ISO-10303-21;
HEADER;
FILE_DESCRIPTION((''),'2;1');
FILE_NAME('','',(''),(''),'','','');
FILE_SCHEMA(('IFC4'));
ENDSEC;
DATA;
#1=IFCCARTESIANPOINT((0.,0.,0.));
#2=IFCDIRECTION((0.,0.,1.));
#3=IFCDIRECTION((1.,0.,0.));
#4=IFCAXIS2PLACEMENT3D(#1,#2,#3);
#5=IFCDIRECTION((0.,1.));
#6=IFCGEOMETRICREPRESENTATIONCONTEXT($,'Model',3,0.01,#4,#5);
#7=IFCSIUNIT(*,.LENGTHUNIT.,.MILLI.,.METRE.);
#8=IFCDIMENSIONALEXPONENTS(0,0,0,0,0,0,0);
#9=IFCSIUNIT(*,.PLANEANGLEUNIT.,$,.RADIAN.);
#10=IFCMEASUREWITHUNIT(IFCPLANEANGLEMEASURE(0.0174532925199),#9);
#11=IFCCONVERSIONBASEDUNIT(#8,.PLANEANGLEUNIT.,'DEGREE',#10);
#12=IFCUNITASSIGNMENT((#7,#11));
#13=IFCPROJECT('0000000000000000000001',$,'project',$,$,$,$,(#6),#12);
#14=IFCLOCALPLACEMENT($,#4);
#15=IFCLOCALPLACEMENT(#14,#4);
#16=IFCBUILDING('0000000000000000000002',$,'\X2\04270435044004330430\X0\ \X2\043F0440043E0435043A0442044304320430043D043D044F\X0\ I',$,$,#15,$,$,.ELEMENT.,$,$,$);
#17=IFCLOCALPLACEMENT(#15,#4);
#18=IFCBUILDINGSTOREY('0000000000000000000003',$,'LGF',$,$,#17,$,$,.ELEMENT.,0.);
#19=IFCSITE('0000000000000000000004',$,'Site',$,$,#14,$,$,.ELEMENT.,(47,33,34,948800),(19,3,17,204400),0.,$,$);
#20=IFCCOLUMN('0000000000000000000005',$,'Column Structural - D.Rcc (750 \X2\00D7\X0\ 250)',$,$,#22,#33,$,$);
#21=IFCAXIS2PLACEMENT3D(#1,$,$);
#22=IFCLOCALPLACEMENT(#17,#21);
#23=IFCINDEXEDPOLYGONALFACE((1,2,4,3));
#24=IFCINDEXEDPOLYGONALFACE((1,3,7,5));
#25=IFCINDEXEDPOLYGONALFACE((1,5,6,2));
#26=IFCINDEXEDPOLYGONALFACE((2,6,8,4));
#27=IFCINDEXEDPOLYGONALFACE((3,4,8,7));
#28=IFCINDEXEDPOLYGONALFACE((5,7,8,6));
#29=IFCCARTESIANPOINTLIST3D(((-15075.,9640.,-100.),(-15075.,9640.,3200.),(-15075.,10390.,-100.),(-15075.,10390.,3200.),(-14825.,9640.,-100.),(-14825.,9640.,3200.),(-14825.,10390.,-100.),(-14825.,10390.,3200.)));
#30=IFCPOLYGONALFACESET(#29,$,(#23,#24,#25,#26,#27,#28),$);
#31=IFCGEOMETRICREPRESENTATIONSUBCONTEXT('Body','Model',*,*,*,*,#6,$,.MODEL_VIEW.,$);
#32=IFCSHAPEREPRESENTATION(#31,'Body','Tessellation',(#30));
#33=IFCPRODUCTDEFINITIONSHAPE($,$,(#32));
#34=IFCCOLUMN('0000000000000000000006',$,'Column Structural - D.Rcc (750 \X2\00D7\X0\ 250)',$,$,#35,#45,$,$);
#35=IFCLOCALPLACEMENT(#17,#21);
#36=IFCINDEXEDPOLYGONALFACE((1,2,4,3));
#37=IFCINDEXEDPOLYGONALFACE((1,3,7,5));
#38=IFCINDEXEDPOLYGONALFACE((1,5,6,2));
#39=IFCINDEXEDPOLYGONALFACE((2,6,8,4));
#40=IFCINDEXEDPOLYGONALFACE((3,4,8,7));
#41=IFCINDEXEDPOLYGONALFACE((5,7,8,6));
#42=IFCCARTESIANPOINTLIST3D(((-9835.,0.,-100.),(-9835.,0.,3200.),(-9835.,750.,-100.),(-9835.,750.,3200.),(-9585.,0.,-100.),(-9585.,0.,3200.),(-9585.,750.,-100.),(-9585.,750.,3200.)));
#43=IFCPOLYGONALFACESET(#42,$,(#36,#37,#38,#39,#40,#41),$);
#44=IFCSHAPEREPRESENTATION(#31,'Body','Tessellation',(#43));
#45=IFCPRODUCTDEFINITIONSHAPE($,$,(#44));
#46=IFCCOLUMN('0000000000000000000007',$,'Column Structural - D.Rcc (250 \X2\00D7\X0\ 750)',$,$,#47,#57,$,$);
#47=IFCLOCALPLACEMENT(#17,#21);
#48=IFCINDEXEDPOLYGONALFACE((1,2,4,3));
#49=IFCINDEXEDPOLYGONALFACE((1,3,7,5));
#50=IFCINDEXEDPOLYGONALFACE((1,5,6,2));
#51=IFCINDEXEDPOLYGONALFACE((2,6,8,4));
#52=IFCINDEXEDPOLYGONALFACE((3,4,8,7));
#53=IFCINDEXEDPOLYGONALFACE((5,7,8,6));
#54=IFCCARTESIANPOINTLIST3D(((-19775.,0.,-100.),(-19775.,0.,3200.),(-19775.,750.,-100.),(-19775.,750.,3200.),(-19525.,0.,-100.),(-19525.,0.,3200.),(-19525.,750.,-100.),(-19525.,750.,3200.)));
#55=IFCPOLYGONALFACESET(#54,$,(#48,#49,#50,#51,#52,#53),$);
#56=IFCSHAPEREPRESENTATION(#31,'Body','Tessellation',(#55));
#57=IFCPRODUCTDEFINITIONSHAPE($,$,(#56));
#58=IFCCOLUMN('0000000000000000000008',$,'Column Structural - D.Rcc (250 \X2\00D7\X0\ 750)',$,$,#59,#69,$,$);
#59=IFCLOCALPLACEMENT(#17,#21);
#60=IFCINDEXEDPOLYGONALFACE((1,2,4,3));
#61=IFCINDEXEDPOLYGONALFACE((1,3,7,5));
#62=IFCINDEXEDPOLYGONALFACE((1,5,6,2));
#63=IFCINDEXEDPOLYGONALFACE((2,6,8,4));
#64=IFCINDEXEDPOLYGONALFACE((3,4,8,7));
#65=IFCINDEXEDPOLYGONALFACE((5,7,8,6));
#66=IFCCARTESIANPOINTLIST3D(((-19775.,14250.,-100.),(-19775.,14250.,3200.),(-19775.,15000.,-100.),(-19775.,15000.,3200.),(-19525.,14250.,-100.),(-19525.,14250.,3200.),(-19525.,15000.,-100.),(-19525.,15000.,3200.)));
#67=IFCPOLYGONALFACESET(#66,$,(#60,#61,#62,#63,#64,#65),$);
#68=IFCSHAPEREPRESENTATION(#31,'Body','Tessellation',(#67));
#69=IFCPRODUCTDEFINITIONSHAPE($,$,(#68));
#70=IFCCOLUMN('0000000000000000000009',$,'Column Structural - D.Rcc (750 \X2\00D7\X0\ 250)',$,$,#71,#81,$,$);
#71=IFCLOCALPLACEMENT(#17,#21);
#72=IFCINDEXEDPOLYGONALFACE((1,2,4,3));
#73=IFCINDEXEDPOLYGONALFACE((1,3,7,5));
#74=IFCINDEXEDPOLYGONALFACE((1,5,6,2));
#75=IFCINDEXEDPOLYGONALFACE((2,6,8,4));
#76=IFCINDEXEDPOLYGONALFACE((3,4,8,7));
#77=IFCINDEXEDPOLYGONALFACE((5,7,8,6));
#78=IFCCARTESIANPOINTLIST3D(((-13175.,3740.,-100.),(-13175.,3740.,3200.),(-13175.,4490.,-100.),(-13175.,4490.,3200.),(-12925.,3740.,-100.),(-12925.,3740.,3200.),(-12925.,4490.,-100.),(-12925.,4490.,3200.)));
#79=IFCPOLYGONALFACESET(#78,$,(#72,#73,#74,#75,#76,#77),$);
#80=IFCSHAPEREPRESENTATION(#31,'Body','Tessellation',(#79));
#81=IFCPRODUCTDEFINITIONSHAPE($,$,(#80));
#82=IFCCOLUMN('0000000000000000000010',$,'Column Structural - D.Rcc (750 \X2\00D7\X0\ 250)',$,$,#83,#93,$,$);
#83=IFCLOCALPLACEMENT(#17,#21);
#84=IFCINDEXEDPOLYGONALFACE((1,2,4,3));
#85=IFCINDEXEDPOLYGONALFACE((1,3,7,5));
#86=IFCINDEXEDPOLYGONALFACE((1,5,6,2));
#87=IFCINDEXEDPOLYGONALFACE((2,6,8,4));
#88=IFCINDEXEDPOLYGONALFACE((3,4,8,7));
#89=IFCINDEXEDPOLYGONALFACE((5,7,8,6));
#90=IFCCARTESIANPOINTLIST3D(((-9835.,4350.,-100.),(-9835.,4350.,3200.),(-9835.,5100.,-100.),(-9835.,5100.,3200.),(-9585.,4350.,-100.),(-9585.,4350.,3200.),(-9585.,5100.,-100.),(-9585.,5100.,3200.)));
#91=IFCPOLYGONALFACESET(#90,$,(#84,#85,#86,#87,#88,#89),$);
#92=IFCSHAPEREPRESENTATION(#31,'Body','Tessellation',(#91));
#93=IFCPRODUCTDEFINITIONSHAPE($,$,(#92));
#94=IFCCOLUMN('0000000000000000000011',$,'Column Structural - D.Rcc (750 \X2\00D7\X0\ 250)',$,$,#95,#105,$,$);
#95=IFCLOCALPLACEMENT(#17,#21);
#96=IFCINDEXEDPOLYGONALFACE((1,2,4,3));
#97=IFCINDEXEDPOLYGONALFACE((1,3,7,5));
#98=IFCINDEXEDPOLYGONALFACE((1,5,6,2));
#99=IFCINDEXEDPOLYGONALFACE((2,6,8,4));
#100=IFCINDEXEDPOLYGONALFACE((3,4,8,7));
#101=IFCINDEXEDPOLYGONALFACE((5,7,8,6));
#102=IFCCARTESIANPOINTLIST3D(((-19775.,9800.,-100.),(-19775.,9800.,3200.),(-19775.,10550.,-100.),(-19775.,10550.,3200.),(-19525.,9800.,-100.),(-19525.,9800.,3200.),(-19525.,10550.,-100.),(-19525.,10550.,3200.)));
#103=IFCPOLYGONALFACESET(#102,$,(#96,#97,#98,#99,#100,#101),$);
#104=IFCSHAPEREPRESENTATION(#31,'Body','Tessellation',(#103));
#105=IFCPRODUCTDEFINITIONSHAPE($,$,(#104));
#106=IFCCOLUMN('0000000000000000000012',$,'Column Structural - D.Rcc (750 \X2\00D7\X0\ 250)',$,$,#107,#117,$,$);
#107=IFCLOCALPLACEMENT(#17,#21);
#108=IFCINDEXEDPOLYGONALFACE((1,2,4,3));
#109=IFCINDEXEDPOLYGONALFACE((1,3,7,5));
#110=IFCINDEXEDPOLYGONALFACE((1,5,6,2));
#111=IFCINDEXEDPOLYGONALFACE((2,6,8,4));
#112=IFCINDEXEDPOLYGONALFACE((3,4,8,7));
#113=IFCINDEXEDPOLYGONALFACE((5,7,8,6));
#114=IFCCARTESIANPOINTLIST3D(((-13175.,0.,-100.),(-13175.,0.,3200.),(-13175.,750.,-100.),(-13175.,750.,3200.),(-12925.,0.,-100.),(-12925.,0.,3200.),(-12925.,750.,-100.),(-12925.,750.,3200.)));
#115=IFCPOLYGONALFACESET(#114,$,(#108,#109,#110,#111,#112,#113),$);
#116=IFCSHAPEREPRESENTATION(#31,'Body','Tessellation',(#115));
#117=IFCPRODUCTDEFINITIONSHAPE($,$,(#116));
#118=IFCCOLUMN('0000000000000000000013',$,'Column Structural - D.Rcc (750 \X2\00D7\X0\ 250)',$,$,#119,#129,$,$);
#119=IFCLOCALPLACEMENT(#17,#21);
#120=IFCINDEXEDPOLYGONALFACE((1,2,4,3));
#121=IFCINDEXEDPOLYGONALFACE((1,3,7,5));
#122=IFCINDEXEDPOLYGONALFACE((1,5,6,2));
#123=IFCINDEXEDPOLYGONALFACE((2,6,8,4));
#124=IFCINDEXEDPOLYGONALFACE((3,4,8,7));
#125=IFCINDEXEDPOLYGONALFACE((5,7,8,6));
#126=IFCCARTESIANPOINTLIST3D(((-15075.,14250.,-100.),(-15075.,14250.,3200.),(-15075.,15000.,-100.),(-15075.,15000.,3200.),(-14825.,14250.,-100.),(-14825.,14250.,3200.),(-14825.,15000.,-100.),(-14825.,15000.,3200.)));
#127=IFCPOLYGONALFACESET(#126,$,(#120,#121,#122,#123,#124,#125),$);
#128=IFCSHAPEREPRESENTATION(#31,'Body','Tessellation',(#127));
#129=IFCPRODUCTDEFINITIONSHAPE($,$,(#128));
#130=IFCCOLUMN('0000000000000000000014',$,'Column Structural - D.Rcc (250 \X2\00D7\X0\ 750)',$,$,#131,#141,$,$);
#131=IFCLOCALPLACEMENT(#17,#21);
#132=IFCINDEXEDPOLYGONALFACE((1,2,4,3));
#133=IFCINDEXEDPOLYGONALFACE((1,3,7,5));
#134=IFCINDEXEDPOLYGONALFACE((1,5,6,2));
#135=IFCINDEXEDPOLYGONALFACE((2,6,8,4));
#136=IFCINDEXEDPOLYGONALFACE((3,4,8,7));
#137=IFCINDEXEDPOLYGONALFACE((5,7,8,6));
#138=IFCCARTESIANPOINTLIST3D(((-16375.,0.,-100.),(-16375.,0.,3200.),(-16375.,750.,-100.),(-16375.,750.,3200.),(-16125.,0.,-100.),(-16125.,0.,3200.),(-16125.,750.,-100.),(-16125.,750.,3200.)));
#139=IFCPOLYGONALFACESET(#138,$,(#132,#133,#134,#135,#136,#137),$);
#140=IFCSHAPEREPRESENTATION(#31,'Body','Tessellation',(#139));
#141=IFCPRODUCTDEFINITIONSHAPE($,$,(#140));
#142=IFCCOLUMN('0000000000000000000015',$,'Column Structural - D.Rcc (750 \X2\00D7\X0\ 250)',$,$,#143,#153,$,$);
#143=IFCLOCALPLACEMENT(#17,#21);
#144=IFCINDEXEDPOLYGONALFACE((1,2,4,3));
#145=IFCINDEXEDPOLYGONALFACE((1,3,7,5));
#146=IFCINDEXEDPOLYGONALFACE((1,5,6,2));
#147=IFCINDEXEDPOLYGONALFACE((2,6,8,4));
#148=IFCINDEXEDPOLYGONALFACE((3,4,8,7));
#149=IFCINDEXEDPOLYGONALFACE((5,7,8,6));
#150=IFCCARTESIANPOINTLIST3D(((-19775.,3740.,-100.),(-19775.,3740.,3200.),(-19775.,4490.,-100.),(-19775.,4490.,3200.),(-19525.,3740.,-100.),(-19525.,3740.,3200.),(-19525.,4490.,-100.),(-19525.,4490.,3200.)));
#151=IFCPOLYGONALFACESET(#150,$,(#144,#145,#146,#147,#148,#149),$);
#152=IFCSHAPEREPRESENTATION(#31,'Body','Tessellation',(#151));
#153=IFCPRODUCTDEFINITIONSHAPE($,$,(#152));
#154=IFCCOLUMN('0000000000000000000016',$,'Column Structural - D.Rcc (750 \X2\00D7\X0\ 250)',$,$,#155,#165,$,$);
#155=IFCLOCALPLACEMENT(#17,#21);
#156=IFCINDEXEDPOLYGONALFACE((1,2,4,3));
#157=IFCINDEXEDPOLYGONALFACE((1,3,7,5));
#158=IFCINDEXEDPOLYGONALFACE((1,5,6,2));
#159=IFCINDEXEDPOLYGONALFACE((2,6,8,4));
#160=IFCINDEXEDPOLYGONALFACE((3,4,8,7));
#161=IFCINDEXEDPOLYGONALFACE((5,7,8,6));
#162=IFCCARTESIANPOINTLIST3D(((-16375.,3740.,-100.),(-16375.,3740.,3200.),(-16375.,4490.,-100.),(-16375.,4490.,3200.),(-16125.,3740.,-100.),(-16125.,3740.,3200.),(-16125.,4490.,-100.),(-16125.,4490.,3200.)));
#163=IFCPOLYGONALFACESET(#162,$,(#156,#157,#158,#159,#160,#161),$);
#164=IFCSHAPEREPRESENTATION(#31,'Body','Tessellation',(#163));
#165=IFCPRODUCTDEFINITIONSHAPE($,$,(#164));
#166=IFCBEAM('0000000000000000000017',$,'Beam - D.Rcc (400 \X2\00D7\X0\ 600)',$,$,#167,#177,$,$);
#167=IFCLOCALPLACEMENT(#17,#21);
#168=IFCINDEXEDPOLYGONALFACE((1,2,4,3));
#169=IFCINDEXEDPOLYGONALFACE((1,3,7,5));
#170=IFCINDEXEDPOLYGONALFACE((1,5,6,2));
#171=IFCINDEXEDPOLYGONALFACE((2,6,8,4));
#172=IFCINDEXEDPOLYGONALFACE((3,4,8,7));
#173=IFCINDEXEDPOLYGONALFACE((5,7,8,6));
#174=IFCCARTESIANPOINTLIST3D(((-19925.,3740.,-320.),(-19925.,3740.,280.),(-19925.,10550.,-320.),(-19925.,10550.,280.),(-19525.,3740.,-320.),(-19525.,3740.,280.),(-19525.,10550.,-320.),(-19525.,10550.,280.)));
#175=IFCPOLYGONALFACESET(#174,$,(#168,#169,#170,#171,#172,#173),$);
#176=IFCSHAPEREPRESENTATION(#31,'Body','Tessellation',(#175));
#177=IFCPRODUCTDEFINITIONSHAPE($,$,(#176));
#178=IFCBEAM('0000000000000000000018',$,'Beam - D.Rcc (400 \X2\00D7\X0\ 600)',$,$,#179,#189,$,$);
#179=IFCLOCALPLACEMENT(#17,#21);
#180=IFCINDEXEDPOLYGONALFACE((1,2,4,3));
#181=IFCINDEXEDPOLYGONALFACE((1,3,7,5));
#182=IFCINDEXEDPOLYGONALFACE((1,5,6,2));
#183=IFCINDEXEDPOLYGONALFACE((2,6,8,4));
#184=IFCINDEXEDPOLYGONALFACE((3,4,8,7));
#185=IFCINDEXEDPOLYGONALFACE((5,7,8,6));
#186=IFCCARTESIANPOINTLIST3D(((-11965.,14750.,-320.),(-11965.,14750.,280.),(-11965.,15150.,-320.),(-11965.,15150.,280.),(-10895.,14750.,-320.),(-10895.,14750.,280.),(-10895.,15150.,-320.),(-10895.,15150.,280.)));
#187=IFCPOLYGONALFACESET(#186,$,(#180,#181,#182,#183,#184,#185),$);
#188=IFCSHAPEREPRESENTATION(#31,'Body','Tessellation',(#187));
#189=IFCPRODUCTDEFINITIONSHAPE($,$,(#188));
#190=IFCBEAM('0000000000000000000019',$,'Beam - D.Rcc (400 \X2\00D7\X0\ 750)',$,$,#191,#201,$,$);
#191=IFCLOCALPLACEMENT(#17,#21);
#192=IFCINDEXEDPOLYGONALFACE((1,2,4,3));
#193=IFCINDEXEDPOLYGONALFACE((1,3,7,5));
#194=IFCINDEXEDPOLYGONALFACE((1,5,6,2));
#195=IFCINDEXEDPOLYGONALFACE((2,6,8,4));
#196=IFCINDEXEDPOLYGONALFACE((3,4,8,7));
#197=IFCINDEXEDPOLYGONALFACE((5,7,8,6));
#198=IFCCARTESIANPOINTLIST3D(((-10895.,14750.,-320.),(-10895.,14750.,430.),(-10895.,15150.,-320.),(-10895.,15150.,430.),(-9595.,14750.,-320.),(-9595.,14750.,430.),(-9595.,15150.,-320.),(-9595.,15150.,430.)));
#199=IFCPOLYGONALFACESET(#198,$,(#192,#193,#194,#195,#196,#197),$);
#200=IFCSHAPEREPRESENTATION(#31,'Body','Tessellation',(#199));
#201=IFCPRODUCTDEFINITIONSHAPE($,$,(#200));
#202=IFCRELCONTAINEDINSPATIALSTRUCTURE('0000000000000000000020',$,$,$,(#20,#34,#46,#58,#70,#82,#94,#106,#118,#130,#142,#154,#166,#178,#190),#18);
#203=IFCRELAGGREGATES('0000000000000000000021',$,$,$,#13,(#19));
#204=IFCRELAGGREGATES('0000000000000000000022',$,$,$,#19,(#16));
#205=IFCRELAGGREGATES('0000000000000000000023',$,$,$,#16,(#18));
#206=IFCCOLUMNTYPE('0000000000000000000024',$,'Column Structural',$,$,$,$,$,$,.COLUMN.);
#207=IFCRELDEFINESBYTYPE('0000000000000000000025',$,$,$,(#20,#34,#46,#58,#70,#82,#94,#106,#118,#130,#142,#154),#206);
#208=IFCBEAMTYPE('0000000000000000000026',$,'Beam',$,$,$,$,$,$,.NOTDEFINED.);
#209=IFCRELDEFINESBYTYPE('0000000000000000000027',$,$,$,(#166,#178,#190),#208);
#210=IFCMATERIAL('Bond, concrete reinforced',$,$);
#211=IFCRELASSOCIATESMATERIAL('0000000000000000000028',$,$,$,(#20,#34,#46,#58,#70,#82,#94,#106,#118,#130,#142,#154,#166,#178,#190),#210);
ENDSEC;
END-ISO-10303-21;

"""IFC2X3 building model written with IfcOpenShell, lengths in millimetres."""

from ifc_helpers import new_model, entity, si_unit, converted_unit, direction, frame, frame_2d, origin_with_axes, origin_2d_with_axis, place, context, subcontext, project, spatial, rectangle, extrude, material, type_object, element, save


model = new_model("IFC2X3")

# Units and contexts
model_context = context("Model", 3, precision=0.01, world=origin_with_axes(), true_north=direction((0.0, 1.0)))
body_context = subcontext(model_context, "Body", "Model", "MODEL_VIEW")
ifc_project = project(units=[si_unit("LENGTHUNIT", "METRE", prefix="MILLI"), converted_unit("PLANEANGLEUNIT", "DEGREE", entity("IfcPlaneAngleMeasure", 0.0174532925199), si_unit("PLANEANGLEUNIT", "RADIAN"), dimensions=[0, 0, 0, 0, 0, 0, 0])], contexts=[model_context])

# Site, building, storey
site_placement = place(None, origin_with_axes())
site = spatial("IfcSite", under=ifc_project, at=site_placement, Name="Site", CompositionType="ELEMENT", RefLatitude=(47, 33, 34, 948800), RefLongitude=(19, 3, 17, 204400), RefElevation=0.0)
building_placement = place(site_placement, origin_with_axes())
building = spatial("IfcBuilding", under=site, at=building_placement, Name="Черга проектування I", CompositionType="ELEMENT")
storey_placement = place(building_placement, origin_with_axes())
storey = spatial("IfcBuildingStorey", under=building, at=storey_placement, Name="LGF", CompositionType="ELEMENT", Elevation=0.0)

# Columns
ifc_material = material(Name="Bond, concrete reinforced")
column_type = type_object("IfcColumnType", Name="Column Structural", PredefinedType="COLUMN")
for number, where, z_axis, x_axis, name in (
    (1, (-14950.0, 10015.0, -100.0), (0.0, 0.0, 1.0), (1.0, 0.0, 0.0), "Column Structural - D.Rcc (750 × 250)"),
    (2, (-9710.0, 375.0, -100.0), (0.0, 0.0, 1.0), (1.0, 0.0, 0.0), "Column Structural - D.Rcc (750 × 250)"),
):
    element("IfcColumn", number, at=place(storey_placement, frame(where, z_axis=z_axis, x_axis=x_axis)), inside=storey, type_object=column_type, material=ifc_material, Name=name, context=body_context, shape_type="SweptSolid", body=[
        extrude(rectangle(XDim=250.0, YDim=750.0, at=origin_2d_with_axis()), origin_with_axes(), (0.0, 0.0, 1.0), 3300.0),
    ])
for number, where, z_axis, x_axis, name in (
    (3, (-19650.0, 375.0, -100.0), (0.0, 0.0, 1.0), (0.0, 1.0, 0.0), "Column Structural - D.Rcc (250 × 750)"),
    (4, (-19650.0, 14625.0, -100.0), (0.0, 0.0, 1.0), (0.0, -1.0, 0.0), "Column Structural - D.Rcc (250 × 750)"),
):
    element("IfcColumn", number, at=place(storey_placement, frame(where, z_axis=z_axis, x_axis=x_axis)), inside=storey, type_object=column_type, material=ifc_material, Name=name, context=body_context, shape_type="SweptSolid", body=[
        extrude(rectangle(XDim=750.0, YDim=250.0, at=origin_2d_with_axis()), origin_with_axes(), (0.0, 0.0, 1.0), 3300.0),
    ])
for number, where, z_axis, x_axis, name in (
    (5, (-13050.0, 4115.0, -100.0), (0.0, 0.0, 1.0), (1.0, 0.0, 0.0), "Column Structural - D.Rcc (750 × 250)"),
    (6, (-9710.0, 4725.0, -100.0), (0.0, 0.0, 1.0), (1.0, 0.0, 0.0), "Column Structural - D.Rcc (750 × 250)"),
    (7, (-19650.0, 10175.0, -100.0), (0.0, 0.0, 1.0), (1.0, 0.0, 0.0), "Column Structural - D.Rcc (750 × 250)"),
    (8, (-13050.0, 375.0, -100.0), (0.0, 0.0, 1.0), (1.0, 0.0, 0.0), "Column Structural - D.Rcc (750 × 250)"),
    (9, (-14950.0, 14625.0, -100.0), (0.0, 0.0, 1.0), (1.0, 0.0, 0.0), "Column Structural - D.Rcc (750 × 250)"),
):
    element("IfcColumn", number, at=place(storey_placement, frame(where, z_axis=z_axis, x_axis=x_axis)), inside=storey, type_object=column_type, material=ifc_material, Name=name, context=body_context, shape_type="SweptSolid", body=[
        extrude(rectangle(XDim=250.0, YDim=750.0, at=origin_2d_with_axis()), origin_with_axes(), (0.0, 0.0, 1.0), 3300.0),
    ])
column_placement = place(storey_placement, frame((-16250.0, 375.0, -100.0), z_axis=(0.0, 0.0, 1.0), x_axis=(0.0, 1.0, 0.0)))
element("IfcColumn", 10, at=column_placement, inside=storey, type_object=column_type, material=ifc_material, Name="Column Structural - D.Rcc (250 × 750)", context=body_context, shape_type="SweptSolid", body=[
    extrude(rectangle(XDim=750.0, YDim=250.0, at=origin_2d_with_axis()), origin_with_axes(), (0.0, 0.0, 1.0), 3300.0),
])
for number, where, z_axis, x_axis, name in (
    (11, (-19650.0, 4115.0, -100.0), (0.0, 0.0, 1.0), (1.0, 0.0, 0.0), "Column Structural - D.Rcc (750 × 250)"),
    (12, (-16250.0, 4115.0, -100.0), (0.0, 0.0, 1.0), (1.0, 0.0, 0.0), "Column Structural - D.Rcc (750 × 250)"),
):
    element("IfcColumn", number, at=place(storey_placement, frame(where, z_axis=z_axis, x_axis=x_axis)), inside=storey, type_object=column_type, material=ifc_material, Name=name, context=body_context, shape_type="SweptSolid", body=[
        extrude(rectangle(XDim=250.0, YDim=750.0, at=origin_2d_with_axis()), origin_with_axes(), (0.0, 0.0, 1.0), 3300.0),
    ])

# Beams
beam_type = type_object("IfcBeamType", Name="Beam", PredefinedType="NOTDEFINED")
beam_1_placement = place(storey_placement, frame((-19725.0, 3740.0, -320.0), z_axis=(0.0, 0.0, 1.0), x_axis=(1.0, 0.0, 0.0)))
element("IfcBeam", 13, at=beam_1_placement, inside=storey, type_object=beam_type, material=ifc_material, Name="Beam - D.Rcc (400 × 600)", context=body_context, shape_type="SweptSolid", body=[
    extrude(rectangle(XDim=600.0, YDim=400.0, at=frame_2d((300.0, 0.0), x_axis=(1.0, 0.0))), frame((0.0, 0.0, 0.0), z_axis=(0.0, 1.0, 0.0), x_axis=(0.0, 0.0, 1.0)), (0.0, 0.0, 1.0), 6810.0),
])
beam_2_placement = place(storey_placement, frame((-11965.0, 14750.0, -320.0), z_axis=(0.0, 0.0, 1.0), x_axis=(0.0, -1.0, 0.0)))
element("IfcBeam", 14, at=beam_2_placement, inside=storey, type_object=beam_type, material=ifc_material, Name="Beam - D.Rcc (400 × 600)", context=body_context, shape_type="SweptSolid", body=[
    extrude(rectangle(XDim=600.0, YDim=400.0, at=frame_2d((300.0, -200.0), x_axis=(1.0, 0.0))), frame((0.0, 0.0, 0.0), z_axis=(0.0, 1.0, 0.0), x_axis=(0.0, 0.0, 1.0)), (0.0, 0.0, 1.0), 1070.0),
])
beam_3_placement = place(storey_placement, frame((-10895.0, 14750.0, -320.0), z_axis=(0.0, 0.0, 1.0), x_axis=(0.0, -1.0, 0.0)))
element("IfcBeam", 15, at=beam_3_placement, inside=storey, type_object=beam_type, material=ifc_material, Name="Beam - D.Rcc (400 × 750)", context=body_context, shape_type="SweptSolid", body=[
    extrude(rectangle(XDim=750.0, YDim=400.0, at=frame_2d((375.0, -200.0), x_axis=(1.0, 0.0))), frame((0.0, 0.0, 0.0), z_axis=(0.0, 1.0, 0.0), x_axis=(0.0, 0.0, 1.0)), (0.0, 0.0, 1.0), 1300.0),
])

save(model, "model.ifc")
